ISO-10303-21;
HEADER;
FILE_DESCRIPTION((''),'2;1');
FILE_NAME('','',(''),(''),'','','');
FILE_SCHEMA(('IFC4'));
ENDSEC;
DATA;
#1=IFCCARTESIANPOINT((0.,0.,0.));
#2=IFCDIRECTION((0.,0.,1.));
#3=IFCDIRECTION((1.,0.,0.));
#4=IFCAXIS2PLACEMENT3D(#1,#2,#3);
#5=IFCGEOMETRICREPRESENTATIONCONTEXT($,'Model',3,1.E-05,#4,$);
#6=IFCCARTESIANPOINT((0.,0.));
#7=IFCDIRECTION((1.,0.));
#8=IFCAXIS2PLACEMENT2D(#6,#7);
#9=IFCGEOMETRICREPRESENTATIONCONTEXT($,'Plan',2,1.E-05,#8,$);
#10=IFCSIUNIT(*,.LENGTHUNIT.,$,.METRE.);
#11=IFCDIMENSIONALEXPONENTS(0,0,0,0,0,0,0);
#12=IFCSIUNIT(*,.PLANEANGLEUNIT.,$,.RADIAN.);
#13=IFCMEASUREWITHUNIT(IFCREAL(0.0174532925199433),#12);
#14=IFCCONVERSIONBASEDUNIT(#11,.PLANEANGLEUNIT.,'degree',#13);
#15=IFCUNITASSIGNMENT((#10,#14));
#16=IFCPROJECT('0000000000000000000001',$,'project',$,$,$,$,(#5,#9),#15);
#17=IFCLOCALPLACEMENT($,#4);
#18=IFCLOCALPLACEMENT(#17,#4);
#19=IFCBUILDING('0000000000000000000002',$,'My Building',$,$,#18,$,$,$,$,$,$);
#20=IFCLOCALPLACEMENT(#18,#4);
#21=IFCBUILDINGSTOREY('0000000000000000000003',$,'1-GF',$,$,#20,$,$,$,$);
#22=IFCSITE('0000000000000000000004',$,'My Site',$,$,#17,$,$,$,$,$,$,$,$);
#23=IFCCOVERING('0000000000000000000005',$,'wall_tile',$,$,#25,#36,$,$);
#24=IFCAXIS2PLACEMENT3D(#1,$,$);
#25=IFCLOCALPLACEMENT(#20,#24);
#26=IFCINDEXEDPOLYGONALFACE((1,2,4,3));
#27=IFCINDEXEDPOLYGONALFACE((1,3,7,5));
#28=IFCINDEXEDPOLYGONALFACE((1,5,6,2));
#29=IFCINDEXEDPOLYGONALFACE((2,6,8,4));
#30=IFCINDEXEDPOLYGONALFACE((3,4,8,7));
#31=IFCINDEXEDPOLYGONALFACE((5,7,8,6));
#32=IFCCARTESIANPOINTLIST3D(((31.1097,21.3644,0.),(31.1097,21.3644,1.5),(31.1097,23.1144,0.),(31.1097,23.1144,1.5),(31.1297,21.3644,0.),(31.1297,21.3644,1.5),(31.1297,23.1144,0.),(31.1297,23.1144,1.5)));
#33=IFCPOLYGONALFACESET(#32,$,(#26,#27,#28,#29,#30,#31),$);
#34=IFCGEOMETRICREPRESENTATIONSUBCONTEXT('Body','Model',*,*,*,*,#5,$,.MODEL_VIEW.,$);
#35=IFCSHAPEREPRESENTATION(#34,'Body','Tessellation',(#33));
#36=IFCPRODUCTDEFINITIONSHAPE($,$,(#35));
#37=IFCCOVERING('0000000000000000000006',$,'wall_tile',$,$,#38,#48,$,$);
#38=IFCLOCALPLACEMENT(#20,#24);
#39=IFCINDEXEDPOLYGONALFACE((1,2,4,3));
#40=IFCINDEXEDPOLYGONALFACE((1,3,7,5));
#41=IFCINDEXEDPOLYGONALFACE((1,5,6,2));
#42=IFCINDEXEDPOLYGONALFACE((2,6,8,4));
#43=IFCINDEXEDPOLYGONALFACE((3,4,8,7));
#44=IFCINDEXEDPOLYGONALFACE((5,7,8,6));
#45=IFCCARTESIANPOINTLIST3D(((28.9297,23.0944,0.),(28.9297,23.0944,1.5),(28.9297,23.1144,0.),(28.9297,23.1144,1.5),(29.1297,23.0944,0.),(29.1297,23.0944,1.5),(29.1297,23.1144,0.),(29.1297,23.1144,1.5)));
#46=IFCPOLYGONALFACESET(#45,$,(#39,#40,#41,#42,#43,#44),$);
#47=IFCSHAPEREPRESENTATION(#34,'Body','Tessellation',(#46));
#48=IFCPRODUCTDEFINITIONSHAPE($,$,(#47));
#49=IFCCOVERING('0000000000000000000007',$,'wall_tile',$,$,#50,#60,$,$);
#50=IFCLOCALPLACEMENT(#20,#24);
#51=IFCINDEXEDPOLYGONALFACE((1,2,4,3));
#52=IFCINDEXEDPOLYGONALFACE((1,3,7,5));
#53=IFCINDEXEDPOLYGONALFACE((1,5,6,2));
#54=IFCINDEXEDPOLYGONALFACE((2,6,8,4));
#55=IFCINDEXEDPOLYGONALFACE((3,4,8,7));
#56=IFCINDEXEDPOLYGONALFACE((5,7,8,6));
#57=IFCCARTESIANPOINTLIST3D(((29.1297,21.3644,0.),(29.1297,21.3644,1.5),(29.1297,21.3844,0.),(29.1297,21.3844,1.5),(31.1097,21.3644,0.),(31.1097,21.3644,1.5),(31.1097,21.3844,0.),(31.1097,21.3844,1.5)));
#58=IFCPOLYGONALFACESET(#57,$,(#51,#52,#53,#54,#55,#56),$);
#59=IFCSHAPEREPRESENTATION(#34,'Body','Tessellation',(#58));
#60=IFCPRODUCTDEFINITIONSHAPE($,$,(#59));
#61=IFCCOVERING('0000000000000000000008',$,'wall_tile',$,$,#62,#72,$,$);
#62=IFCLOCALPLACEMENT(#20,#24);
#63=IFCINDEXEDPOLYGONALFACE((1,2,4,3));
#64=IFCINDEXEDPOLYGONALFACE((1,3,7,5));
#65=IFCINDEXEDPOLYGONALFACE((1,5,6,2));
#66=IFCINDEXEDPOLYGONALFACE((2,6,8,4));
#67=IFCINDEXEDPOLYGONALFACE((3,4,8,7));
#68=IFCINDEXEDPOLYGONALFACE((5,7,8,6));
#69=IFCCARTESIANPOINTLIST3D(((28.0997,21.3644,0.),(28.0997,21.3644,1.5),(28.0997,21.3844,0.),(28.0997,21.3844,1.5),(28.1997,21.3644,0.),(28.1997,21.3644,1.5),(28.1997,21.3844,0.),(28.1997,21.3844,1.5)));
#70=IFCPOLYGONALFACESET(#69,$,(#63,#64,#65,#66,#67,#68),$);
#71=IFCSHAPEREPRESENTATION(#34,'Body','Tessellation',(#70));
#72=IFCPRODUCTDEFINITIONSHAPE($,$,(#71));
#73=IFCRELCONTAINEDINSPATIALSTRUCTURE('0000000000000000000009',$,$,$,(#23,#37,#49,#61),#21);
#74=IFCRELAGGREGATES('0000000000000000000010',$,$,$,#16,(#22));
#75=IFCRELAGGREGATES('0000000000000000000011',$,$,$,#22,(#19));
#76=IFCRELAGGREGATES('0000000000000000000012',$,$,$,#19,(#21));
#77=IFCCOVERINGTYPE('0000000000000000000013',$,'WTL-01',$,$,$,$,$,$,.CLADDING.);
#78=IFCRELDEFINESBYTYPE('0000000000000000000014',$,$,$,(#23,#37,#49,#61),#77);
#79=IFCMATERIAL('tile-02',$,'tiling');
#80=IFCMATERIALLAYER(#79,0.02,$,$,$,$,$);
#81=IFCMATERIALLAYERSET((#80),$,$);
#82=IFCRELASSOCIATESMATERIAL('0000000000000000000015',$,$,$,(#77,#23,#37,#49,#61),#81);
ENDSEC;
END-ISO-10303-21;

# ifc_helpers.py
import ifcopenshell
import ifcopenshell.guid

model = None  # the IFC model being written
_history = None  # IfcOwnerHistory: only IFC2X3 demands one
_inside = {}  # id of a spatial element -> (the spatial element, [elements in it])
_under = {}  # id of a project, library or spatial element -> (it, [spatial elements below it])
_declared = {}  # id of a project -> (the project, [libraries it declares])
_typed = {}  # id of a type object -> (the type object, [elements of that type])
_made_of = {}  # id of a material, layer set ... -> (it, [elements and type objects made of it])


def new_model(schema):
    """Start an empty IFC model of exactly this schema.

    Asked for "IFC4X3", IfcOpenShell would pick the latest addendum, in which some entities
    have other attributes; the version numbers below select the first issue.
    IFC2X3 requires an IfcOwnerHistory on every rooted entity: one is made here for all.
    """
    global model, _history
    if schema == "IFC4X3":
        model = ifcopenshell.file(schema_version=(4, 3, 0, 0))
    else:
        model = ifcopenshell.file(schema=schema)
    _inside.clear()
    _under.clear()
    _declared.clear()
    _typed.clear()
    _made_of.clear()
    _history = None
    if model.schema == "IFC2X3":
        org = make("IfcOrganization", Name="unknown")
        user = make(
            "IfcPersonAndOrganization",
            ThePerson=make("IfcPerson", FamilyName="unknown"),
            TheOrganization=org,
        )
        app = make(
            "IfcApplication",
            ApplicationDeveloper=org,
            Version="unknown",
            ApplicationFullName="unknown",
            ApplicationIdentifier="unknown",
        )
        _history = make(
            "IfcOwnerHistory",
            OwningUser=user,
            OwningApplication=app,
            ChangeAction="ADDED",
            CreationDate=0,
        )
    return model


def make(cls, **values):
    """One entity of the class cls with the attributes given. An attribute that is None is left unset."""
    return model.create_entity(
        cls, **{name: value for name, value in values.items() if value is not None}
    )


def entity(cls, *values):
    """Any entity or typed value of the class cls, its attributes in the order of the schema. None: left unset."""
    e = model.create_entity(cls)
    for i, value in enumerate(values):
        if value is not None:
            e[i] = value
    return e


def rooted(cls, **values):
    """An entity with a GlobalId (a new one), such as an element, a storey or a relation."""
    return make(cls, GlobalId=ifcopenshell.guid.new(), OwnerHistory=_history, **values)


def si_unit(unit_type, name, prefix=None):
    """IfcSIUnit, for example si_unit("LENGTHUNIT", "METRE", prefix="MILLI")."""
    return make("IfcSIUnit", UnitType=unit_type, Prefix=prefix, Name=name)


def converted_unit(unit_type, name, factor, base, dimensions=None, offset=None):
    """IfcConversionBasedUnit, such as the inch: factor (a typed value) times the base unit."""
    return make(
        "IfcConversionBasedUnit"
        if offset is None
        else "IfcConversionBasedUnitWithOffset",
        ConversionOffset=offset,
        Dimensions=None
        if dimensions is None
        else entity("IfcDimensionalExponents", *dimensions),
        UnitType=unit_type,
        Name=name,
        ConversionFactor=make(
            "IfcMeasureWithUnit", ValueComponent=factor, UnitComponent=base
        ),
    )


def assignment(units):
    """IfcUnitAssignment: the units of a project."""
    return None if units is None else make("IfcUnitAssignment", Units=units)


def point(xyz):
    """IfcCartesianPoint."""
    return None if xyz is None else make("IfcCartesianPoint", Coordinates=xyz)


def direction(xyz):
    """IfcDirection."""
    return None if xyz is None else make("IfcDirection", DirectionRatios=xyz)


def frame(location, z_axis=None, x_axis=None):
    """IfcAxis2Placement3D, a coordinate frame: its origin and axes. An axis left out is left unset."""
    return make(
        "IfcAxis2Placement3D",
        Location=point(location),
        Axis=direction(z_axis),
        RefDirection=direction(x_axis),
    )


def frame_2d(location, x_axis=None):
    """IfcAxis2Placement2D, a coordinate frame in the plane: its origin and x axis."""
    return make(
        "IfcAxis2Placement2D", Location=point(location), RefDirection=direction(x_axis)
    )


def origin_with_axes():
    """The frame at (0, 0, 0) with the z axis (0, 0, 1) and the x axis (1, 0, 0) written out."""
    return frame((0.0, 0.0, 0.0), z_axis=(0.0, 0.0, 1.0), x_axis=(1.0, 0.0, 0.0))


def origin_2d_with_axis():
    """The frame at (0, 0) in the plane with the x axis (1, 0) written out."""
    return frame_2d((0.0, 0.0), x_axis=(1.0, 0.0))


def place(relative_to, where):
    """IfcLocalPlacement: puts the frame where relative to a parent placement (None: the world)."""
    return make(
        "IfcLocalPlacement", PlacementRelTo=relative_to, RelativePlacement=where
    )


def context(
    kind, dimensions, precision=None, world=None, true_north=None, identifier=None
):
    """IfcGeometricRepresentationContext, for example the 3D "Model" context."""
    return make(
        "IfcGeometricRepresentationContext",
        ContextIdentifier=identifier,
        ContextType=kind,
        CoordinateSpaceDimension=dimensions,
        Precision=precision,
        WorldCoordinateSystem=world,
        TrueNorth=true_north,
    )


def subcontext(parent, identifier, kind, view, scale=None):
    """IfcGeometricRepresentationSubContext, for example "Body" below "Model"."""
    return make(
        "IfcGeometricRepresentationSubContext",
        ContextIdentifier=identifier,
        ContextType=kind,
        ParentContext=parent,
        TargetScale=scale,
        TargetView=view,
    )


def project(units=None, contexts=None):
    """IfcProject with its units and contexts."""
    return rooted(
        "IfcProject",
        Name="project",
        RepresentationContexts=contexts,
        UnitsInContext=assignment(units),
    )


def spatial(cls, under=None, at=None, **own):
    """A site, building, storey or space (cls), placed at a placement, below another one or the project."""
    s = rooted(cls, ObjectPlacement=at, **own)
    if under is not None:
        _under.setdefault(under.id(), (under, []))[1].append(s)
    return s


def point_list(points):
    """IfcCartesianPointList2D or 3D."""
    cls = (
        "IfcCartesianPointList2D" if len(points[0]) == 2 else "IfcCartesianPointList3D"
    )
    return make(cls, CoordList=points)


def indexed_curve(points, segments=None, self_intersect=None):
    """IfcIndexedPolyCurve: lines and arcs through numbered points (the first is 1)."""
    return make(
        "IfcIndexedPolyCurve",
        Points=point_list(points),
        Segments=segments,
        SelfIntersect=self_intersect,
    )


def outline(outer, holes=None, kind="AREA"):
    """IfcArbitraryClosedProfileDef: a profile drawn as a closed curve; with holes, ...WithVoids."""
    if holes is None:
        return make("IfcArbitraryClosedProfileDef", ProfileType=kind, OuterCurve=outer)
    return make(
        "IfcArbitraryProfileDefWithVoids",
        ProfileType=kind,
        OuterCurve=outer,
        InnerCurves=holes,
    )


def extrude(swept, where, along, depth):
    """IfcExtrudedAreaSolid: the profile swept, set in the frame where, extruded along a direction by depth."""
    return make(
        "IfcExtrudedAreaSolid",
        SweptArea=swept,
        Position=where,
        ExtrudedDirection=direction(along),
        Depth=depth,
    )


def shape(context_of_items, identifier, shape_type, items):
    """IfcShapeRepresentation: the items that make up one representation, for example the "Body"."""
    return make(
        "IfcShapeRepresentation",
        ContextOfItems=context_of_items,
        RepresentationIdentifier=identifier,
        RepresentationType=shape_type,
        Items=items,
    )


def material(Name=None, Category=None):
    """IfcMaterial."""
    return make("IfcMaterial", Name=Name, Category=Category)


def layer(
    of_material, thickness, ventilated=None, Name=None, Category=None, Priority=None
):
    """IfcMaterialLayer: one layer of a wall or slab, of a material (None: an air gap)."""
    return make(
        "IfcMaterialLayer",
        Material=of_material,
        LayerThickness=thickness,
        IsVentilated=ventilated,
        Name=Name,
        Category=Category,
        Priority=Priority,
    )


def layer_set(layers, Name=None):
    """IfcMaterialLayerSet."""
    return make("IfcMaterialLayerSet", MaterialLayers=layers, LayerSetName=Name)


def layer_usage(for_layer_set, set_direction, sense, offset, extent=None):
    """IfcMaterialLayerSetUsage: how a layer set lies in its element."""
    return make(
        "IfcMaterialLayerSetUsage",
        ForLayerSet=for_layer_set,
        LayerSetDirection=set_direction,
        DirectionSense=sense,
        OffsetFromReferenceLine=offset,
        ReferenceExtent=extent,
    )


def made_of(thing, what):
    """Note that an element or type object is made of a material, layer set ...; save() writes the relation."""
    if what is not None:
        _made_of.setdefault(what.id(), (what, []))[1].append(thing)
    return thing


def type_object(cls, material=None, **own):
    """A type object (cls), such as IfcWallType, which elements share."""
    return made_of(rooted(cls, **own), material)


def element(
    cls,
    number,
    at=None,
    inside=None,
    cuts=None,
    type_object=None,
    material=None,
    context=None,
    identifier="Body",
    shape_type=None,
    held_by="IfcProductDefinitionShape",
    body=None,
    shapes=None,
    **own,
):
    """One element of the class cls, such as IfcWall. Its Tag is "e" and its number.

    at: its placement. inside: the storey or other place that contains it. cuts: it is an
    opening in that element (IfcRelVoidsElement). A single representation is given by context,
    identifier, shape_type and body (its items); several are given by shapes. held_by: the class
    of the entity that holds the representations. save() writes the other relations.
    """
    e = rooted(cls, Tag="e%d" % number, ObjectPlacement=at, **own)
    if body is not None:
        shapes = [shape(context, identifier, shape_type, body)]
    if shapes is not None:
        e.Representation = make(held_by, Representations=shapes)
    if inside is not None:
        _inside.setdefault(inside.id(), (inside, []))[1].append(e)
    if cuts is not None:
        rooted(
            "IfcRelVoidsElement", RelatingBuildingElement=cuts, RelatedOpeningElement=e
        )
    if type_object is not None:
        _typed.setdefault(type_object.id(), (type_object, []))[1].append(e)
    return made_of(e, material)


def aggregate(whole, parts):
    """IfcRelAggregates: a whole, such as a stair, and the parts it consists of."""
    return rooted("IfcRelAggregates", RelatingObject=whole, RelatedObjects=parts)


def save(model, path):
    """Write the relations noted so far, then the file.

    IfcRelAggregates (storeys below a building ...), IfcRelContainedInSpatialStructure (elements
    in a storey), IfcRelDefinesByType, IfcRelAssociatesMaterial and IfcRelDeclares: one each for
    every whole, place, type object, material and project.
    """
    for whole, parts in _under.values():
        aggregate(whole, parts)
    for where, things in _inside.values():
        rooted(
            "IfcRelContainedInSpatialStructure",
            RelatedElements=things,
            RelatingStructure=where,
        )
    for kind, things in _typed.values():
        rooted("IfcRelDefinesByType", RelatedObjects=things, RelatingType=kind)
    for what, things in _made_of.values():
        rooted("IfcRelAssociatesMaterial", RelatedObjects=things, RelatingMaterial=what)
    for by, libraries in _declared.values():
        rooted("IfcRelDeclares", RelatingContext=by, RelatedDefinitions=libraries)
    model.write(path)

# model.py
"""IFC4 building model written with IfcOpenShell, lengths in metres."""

from ifc_helpers import new_model, entity, si_unit, converted_unit, frame, origin_with_axes, origin_2d_with_axis, place, context, subcontext, project, spatial, indexed_curve, outline, extrude, material, layer, layer_set, layer_usage, type_object, element, save


model = new_model("IFC4")

# Units and contexts
model_context = context("Model", 3, precision=1e-05, world=origin_with_axes())
plan_context = context("Plan", 2, precision=1e-05, world=origin_2d_with_axis())
body_context_1 = subcontext(model_context, "Body", "Model", "MODEL_VIEW")
ifc_project = project(units=[si_unit("LENGTHUNIT", "METRE"), converted_unit("PLANEANGLEUNIT", "degree", entity("IfcReal", 0.0174532925199433), si_unit("PLANEANGLEUNIT", "RADIAN"), dimensions=[0, 0, 0, 0, 0, 0, 0])], contexts=[model_context, plan_context])

# Site, building, storey
site_placement = place(None, origin_with_axes())
site = spatial("IfcSite", under=ifc_project, at=site_placement, Name="My Site")
building_placement = place(site_placement, origin_with_axes())
building = spatial("IfcBuilding", under=site, at=building_placement, Name="My Building")
storey_placement = place(building_placement, origin_with_axes())
storey = spatial("IfcBuildingStorey", under=building, at=storey_placement, Name="1-GF")

# Coverings
ifc_material_1 = material(Name="tile-02", Category="tiling")
ifc_layer_1 = layer(ifc_material_1, 0.02)
ifc_layer_set_1 = layer_set([ifc_layer_1])
covering_type_1 = type_object("IfcCoveringType", Name="WTL-01", PredefinedType="CLADDING", material=ifc_layer_set_1)
ifc_layer_usage_1 = layer_usage(ifc_layer_set_1, "AXIS2", "POSITIVE", 0.0)
covering_1_placement = place(storey_placement, frame((31.1297, 21.3644, 0.0), z_axis=(0.0, 0.0, 1.0), x_axis=(0.000001, 1.0, 0.0)))
element("IfcCovering", 1, at=covering_1_placement, inside=storey, type_object=covering_type_1, material=ifc_layer_usage_1, Name="wall_tile", context=body_context_1, shape_type="SweptSolid", body=[
    extrude(outline(indexed_curve([(0.0, 0.0), (0.0, 0.02), (1.75, 0.02), (1.75, 0.0), (0.0, 0.0)], self_intersect=False)), origin_with_axes(), (0.0, 0.0, 1.0), 1.5),
])
ifc_layer_usage_2 = layer_usage(ifc_layer_set_1, "AXIS2", "POSITIVE", 0.0)
covering_2_placement = place(storey_placement, frame((29.1297, 23.1144, 0.0), z_axis=(0.0, 0.0, 1.0), x_axis=(-1.0, 0.000001, 0.0)))
element("IfcCovering", 2, at=covering_2_placement, inside=storey, type_object=covering_type_1, material=ifc_layer_usage_2, Name="wall_tile", context=body_context_1, shape_type="SweptSolid", body=[
    extrude(outline(indexed_curve([(0.0, 0.0), (0.0, 0.02), (0.2, 0.02), (0.2, 0.0), (0.0, 0.0)], self_intersect=False)), origin_with_axes(), (0.0, 0.0, 1.0), 1.5),
])
ifc_layer_usage_3 = layer_usage(ifc_layer_set_1, "AXIS2", "POSITIVE", 0.0)
covering_3_placement = place(storey_placement, frame((31.1097, 21.3844, 0.0), z_axis=(0.0, 0.0, 1.0), x_axis=(-1.0, 0.000001, 0.0)))
element("IfcCovering", 3, at=covering_3_placement, inside=storey, type_object=covering_type_1, material=ifc_layer_usage_3, Name="wall_tile", context=body_context_1, shape_type="SweptSolid", body=[
    extrude(outline(indexed_curve([(0.0, 0.0), (0.0, 0.02), (1.98, 0.02), (1.98, 0.0), (0.0, 0.0)], self_intersect=False)), origin_with_axes(), (0.0, 0.0, 1.0), 1.5),
])
ifc_layer_usage_4 = layer_usage(ifc_layer_set_1, "AXIS2", "POSITIVE", 0.0)
covering_4_placement = place(storey_placement, frame((28.1997, 21.3844, 0.0), z_axis=(0.0, 0.0, 1.0), x_axis=(-1.0, 0.000001, 0.0)))
element("IfcCovering", 4, at=covering_4_placement, inside=storey, type_object=covering_type_1, material=ifc_layer_usage_4, Name="wall_tile", context=body_context_1, shape_type="SweptSolid", body=[
    extrude(outline(indexed_curve([(0.0, 0.0), (0.0, 0.02), (0.1, 0.02), (0.1, 0.0), (0.0, 0.0)], self_intersect=False)), origin_with_axes(), (0.0, 0.0, 1.0), 1.5),
])

save(model, "model.ifc")
